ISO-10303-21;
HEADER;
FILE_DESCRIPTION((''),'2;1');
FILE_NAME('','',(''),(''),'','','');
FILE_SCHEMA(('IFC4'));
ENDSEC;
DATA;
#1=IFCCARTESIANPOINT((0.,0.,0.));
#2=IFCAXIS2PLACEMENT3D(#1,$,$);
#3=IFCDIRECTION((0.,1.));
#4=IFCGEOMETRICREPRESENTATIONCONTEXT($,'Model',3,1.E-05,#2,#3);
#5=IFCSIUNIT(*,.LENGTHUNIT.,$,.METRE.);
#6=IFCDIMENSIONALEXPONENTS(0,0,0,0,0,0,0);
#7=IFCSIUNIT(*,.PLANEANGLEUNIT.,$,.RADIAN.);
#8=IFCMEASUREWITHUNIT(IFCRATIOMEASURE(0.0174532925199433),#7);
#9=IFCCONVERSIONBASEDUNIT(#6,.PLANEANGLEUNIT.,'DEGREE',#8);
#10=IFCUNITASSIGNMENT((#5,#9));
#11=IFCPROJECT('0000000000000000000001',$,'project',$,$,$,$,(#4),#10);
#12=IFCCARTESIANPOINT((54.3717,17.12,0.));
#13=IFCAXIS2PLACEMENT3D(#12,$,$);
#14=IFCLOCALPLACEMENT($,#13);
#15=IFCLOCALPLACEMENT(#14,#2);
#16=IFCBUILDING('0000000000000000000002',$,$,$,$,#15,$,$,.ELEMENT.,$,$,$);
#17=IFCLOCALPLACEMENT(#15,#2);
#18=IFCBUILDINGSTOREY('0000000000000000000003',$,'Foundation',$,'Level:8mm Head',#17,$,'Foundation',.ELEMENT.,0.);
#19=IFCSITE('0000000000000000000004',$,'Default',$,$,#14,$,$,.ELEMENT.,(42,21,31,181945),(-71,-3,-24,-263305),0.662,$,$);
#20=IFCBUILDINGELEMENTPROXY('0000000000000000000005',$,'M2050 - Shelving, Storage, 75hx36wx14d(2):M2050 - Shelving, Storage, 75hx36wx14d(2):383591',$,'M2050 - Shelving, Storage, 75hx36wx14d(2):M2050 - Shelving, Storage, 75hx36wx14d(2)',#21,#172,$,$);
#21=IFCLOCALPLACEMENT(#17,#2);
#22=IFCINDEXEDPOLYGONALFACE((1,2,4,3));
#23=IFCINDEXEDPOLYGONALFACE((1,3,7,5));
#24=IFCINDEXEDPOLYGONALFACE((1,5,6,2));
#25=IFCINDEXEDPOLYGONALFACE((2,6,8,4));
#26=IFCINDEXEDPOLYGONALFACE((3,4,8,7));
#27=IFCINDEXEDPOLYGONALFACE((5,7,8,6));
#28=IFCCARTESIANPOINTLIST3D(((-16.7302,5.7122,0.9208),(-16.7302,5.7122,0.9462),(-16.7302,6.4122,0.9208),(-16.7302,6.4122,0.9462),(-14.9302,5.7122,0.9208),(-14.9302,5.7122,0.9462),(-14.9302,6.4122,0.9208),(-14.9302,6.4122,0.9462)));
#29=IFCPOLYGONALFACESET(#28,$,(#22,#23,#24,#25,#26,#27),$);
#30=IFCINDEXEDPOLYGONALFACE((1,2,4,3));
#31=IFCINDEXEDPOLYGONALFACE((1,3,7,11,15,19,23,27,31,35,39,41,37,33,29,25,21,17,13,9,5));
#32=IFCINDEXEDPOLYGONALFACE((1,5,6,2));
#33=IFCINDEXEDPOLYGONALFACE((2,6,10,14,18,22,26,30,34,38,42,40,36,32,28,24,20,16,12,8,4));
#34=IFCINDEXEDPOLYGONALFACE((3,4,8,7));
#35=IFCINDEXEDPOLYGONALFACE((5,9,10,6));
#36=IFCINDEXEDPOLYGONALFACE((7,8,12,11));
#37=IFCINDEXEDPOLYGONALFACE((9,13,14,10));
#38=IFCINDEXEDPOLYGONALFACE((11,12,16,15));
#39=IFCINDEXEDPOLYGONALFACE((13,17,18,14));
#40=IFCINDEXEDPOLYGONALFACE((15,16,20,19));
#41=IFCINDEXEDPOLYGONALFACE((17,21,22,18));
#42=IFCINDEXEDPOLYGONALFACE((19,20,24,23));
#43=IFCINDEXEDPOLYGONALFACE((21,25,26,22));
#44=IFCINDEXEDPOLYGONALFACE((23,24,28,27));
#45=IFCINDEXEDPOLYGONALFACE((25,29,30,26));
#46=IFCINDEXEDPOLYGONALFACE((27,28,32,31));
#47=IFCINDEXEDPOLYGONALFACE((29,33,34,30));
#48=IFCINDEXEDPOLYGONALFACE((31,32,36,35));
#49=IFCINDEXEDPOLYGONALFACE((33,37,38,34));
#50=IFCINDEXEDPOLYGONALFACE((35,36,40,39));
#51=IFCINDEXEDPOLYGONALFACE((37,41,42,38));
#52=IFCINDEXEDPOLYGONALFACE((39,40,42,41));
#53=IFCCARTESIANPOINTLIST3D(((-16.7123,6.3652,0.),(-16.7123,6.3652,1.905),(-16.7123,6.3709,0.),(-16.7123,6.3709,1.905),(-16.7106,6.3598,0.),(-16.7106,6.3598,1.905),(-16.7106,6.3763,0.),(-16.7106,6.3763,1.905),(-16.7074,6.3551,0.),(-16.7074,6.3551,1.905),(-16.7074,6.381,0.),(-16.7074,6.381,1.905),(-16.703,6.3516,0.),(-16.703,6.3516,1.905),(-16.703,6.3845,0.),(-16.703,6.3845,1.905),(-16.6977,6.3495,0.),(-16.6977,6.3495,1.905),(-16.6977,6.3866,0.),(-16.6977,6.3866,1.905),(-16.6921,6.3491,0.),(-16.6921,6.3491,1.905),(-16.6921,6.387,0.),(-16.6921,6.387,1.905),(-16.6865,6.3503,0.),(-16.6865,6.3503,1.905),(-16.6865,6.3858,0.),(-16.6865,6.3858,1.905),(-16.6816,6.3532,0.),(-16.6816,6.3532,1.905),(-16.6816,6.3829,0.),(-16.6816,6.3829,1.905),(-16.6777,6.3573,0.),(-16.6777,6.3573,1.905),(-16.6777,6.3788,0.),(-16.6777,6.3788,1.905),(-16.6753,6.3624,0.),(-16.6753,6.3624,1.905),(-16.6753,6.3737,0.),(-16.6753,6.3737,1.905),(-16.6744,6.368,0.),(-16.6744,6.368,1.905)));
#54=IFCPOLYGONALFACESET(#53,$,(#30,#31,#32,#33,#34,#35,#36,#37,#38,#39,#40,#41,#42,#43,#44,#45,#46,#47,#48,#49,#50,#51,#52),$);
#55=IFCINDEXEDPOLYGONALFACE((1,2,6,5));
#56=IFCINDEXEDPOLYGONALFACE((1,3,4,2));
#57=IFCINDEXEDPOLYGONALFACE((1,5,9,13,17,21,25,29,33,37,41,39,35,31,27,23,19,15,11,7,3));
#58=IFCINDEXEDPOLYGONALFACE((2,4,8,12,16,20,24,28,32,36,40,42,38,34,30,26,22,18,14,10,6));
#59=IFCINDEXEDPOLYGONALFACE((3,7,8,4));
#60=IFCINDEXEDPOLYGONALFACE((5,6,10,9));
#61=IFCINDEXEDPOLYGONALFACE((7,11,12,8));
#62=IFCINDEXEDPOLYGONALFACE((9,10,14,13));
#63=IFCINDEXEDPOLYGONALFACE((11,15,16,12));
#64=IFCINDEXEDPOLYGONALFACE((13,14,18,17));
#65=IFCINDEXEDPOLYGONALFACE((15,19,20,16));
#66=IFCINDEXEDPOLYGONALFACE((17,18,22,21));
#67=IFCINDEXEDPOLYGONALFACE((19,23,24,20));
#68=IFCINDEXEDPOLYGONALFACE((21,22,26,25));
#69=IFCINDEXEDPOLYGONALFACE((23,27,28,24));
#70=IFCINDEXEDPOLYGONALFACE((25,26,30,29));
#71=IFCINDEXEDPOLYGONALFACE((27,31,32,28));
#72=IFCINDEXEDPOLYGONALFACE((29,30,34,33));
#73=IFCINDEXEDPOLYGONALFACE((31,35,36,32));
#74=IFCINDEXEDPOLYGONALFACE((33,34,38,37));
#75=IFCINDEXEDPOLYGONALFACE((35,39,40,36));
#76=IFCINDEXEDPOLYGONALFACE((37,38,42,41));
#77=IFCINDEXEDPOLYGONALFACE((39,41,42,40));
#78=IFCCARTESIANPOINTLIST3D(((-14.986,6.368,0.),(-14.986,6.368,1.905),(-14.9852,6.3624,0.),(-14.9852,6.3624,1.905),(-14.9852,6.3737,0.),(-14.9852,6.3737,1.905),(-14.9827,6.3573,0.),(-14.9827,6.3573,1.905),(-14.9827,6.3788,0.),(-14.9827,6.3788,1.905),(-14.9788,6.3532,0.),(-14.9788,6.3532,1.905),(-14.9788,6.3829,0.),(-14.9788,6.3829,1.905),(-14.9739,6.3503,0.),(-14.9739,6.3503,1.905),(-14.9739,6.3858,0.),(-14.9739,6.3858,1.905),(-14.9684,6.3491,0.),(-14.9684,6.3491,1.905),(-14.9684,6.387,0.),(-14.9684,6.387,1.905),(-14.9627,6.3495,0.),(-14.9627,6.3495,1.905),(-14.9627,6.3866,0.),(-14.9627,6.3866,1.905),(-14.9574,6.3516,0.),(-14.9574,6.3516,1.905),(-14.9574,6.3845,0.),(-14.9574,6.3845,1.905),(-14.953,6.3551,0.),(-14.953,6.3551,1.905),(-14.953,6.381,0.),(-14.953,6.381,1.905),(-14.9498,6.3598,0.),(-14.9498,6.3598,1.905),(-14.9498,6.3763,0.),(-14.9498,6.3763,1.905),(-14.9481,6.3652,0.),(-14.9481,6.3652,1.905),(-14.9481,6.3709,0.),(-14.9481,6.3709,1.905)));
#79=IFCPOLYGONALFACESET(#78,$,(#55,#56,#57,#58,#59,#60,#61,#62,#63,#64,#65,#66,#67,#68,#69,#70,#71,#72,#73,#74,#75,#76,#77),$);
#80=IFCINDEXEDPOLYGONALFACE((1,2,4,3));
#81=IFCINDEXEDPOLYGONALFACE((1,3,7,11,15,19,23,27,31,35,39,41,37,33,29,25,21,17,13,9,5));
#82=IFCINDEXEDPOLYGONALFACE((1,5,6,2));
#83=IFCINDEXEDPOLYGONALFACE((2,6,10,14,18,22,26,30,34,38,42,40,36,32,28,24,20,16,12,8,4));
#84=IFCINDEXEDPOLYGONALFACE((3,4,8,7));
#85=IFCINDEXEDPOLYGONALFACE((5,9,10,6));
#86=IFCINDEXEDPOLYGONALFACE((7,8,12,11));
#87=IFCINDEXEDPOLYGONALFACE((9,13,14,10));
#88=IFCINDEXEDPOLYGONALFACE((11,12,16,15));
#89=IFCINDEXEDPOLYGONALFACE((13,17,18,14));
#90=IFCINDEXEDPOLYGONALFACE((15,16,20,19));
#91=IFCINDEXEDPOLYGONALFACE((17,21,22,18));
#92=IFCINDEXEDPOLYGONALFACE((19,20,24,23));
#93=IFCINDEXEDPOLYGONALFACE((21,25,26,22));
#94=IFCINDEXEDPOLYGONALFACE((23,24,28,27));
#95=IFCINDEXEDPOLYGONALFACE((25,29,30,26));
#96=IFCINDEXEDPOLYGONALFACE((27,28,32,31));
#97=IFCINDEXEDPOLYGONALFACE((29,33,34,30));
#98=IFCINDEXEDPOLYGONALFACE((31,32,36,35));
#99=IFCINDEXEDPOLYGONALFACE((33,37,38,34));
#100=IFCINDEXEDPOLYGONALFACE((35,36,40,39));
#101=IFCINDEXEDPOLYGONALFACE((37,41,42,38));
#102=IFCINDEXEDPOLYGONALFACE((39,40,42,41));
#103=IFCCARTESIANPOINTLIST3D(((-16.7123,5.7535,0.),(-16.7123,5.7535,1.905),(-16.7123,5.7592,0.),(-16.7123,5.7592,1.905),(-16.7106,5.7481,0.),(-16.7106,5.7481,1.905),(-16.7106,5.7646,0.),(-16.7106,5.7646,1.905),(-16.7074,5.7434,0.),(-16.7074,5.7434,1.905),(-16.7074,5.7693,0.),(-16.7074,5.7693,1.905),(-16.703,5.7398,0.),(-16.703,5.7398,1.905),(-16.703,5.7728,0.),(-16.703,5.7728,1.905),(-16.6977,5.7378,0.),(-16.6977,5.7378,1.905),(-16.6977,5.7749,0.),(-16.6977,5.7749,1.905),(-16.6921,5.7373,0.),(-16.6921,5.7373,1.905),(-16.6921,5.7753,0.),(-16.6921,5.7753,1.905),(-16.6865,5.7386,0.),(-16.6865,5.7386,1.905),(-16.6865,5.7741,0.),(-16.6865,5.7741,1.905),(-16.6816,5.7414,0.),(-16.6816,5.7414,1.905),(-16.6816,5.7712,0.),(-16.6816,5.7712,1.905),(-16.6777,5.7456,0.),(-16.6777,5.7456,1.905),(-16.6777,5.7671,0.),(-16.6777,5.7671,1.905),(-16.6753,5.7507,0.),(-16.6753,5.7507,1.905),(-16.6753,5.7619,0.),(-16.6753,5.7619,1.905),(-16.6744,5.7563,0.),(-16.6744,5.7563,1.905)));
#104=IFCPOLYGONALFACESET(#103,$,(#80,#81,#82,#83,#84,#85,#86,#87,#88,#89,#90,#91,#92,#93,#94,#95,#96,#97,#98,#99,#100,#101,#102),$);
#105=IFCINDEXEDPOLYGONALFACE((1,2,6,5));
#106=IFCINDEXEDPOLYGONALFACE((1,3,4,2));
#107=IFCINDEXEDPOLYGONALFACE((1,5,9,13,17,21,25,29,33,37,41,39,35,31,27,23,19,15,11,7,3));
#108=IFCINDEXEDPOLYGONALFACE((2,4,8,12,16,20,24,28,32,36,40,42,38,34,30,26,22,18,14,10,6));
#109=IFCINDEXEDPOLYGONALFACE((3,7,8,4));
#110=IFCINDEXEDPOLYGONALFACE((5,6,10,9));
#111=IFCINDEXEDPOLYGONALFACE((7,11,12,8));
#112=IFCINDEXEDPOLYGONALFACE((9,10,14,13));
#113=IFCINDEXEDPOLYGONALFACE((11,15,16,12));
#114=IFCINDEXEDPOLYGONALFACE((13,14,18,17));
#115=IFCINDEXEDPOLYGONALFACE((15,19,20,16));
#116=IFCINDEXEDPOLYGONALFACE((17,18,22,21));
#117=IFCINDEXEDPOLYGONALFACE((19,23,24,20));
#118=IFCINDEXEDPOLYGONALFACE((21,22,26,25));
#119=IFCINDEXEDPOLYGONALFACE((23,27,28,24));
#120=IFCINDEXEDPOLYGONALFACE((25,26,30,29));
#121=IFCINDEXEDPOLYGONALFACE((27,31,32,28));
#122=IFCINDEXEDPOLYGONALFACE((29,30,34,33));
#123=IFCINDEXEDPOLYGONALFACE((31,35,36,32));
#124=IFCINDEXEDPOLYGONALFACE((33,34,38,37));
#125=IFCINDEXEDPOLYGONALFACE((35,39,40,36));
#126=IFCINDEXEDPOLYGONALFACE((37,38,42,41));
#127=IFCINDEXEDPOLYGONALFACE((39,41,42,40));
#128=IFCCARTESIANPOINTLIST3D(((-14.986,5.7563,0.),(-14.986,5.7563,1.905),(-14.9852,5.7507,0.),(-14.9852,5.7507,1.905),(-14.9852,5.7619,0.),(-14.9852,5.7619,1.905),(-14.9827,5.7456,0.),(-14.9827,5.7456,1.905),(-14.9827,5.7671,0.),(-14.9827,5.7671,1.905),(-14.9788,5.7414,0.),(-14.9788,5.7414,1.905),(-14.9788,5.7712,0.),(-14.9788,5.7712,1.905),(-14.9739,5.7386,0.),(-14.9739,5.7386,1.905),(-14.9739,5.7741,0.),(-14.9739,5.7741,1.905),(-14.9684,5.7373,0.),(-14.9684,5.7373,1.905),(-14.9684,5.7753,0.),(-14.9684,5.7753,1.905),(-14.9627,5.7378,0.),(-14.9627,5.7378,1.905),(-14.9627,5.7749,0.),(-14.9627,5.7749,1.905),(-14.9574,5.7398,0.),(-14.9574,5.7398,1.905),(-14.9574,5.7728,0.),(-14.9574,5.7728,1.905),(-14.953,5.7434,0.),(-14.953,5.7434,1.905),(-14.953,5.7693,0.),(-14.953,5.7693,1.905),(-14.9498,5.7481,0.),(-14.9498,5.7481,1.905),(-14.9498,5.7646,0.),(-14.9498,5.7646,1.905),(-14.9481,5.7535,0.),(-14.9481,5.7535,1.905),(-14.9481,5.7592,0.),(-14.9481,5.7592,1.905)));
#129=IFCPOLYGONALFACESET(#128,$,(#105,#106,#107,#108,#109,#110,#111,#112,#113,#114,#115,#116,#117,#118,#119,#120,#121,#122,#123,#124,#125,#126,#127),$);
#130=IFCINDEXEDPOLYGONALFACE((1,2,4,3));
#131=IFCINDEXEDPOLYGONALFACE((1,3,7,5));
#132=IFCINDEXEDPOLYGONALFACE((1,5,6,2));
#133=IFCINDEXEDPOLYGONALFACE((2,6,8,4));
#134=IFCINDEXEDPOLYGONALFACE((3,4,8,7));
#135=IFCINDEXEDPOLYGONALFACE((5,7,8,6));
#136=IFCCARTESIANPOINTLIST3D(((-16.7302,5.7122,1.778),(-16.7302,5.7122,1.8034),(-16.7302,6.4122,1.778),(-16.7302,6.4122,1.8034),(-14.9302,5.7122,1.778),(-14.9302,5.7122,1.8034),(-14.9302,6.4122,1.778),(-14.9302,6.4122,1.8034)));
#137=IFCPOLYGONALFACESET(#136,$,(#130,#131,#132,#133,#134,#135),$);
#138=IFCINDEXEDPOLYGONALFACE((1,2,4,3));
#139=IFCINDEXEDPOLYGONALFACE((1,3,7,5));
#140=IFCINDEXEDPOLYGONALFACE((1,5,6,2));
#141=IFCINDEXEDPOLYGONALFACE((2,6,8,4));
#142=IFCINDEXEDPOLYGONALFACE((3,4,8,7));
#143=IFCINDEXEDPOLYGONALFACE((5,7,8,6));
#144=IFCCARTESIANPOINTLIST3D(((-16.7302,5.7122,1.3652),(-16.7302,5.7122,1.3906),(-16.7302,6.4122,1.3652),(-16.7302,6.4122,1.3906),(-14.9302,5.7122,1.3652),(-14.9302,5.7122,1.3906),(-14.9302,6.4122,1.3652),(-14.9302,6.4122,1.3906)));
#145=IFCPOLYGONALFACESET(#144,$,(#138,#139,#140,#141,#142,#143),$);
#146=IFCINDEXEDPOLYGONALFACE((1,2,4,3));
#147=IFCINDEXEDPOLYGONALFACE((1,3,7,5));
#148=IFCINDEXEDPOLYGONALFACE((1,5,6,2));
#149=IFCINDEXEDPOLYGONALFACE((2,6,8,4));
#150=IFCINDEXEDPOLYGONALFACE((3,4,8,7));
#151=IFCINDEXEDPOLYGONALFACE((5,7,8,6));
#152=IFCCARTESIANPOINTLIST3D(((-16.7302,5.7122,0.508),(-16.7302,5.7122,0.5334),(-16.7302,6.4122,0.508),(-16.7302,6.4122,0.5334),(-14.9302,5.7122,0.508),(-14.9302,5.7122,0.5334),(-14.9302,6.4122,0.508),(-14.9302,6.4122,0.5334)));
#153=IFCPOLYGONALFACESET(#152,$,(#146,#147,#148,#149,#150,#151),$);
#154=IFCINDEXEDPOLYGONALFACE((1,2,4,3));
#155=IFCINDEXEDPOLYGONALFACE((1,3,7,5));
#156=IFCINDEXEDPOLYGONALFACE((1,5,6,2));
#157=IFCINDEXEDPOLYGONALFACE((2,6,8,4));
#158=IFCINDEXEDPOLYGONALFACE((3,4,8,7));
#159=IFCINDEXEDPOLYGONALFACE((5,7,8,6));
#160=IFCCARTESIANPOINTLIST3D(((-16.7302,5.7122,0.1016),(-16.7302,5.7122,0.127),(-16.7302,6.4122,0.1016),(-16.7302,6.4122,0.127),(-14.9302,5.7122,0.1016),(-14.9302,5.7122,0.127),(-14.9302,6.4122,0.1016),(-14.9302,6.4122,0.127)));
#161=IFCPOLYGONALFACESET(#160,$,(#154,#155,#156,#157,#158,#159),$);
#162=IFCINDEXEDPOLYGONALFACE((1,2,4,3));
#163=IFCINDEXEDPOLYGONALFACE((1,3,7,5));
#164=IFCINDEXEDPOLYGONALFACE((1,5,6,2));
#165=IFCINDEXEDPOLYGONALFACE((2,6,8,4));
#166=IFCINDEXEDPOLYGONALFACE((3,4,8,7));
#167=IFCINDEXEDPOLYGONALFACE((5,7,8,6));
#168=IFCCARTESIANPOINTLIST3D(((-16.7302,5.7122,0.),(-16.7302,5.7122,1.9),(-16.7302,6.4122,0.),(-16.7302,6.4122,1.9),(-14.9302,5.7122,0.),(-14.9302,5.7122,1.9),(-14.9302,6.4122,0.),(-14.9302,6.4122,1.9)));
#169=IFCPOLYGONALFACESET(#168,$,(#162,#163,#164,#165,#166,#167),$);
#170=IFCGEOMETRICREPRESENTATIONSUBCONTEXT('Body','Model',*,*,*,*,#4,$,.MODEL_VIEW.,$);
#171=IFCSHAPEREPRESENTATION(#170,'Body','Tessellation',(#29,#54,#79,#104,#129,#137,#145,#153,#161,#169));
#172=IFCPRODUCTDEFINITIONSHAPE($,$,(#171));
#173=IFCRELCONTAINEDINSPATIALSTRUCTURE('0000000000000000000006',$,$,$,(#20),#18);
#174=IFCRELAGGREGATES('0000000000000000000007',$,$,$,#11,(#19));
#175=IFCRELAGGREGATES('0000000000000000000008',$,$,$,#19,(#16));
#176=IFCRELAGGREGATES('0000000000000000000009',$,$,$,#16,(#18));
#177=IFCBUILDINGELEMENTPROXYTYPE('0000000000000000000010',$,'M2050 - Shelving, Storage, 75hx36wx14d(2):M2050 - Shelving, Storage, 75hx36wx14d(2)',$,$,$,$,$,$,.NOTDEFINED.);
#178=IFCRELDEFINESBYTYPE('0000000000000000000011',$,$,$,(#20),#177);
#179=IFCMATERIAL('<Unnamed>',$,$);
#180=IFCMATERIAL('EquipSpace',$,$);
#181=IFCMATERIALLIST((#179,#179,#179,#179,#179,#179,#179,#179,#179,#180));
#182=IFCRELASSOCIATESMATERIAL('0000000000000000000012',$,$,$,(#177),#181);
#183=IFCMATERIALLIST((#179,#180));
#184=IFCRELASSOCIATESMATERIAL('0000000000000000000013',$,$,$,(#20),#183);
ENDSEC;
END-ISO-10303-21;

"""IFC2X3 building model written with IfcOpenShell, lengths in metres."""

from ifc_helpers import new_model, entity, si_unit, converted_unit, direction, frame, frame_2d, origin, origin_2d_with_axis, place, context, subcontext, project, spatial, rectangle, circle, extrude, source, transform, mapped, material, material_list, type_object, type_shapes, element, save


model = new_model("IFC2X3")

# Units and contexts
model_context = context("Model", 3, precision=1e-05, world=origin(), true_north=direction((0.0, 1.0)))
body_context = subcontext(model_context, "Body", "Model", "MODEL_VIEW")
ifc_project = project(units=[si_unit("LENGTHUNIT", "METRE"), converted_unit("PLANEANGLEUNIT", "DEGREE", entity("IfcRatioMeasure", 0.0174532925199433), si_unit("PLANEANGLEUNIT", "RADIAN"), dimensions=[0, 0, 0, 0, 0, 0, 0])], contexts=[model_context])

# Site, building, storey
site_placement = place(None, frame((54.3717, 17.12, 0.0)))
site = spatial("IfcSite", under=ifc_project, at=site_placement, Name="Default", CompositionType="ELEMENT", RefLatitude=(42, 21, 31, 181945), RefLongitude=(-71, -3, -24, -263305), RefElevation=0.662)
building_placement = place(site_placement, origin())
building = spatial("IfcBuilding", under=site, at=building_placement, CompositionType="ELEMENT")
storey_placement = place(building_placement, origin())
storey = spatial("IfcBuildingStorey", under=building, at=storey_placement, Name="Foundation", ObjectType="Level:8mm Head", LongName="Foundation", CompositionType="ELEMENT", Elevation=0.0)

# Building element proxy
ifc_material_1 = material(Name="<Unnamed>")
ifc_material_2 = material(Name="EquipSpace")
ifc_material_list_1 = material_list([ifc_material_1, ifc_material_1, ifc_material_1, ifc_material_1, ifc_material_1, ifc_material_1, ifc_material_1, ifc_material_1, ifc_material_1, ifc_material_2])
building_element_proxy_type = type_object("IfcBuildingElementProxyType", Name="M2050 - Shelving, Storage, 75hx36wx14d(2):M2050 - Shelving, Storage, 75hx36wx14d(2)", PredefinedType="NOTDEFINED", material=ifc_material_list_1)
shared_shape = source(origin(), body_context, "Body", "SweptSolid", [
    extrude(rectangle(XDim=1.8, YDim=0.7, at=origin_2d_with_axis()), frame((0.0, 0.0, 0.9207), z_axis=(0.0, 0.0, 1.0), x_axis=(-1.0, 0.0, 0.0)), (0.0, 0.0, 1.0), 0.0254),
    extrude(circle(Radius=0.0191, at=origin_2d_with_axis()), frame((0.8633, -0.3059, 0.0), z_axis=(0.0, 0.0, 1.0), x_axis=(-1.0, 0.0, 0.0)), (0.0, 0.0, 1.0), 1.905),
    extrude(circle(Radius=0.0191, at=origin_2d_with_axis()), frame((-0.8633, -0.3059, 0.0)), (0.0, 0.0, 1.0), 1.905),
    extrude(circle(Radius=0.0191, at=origin_2d_with_axis()), frame((0.8633, 0.3059, 0.0), z_axis=(0.0, 0.0, 1.0), x_axis=(-1.0, 0.0, 0.0)), (0.0, 0.0, 1.0), 1.905),
    extrude(circle(Radius=0.0191, at=origin_2d_with_axis()), frame((-0.8633, 0.3059, 0.0)), (0.0, 0.0, 1.0), 1.905),
    extrude(rectangle(XDim=1.8, YDim=0.7, at=origin_2d_with_axis()), frame((0.0, 0.0, 1.778), z_axis=(0.0, 0.0, 1.0), x_axis=(-1.0, 0.0, 0.0)), (0.0, 0.0, 1.0), 0.0254),
    extrude(rectangle(XDim=1.8, YDim=0.7, at=origin_2d_with_axis()), frame((0.0, 0.0, 1.3653), z_axis=(0.0, 0.0, 1.0), x_axis=(-1.0, 0.0, 0.0)), (0.0, 0.0, 1.0), 0.0254),
    extrude(rectangle(XDim=1.8, YDim=0.7, at=origin_2d_with_axis()), frame((0.0, 0.0, 0.508), z_axis=(0.0, 0.0, 1.0), x_axis=(-1.0, 0.0, 0.0)), (0.0, 0.0, 1.0), 0.0254),
    extrude(rectangle(XDim=1.8, YDim=0.7, at=origin_2d_with_axis()), frame((0.0, 0.0, 0.1016), z_axis=(0.0, 0.0, 1.0), x_axis=(-1.0, 0.0, 0.0)), (0.0, 0.0, 1.0), 0.0254),
    extrude(rectangle(XDim=0.7, YDim=1.8, at=frame_2d((0.0, 0.18), x_axis=(1.0, 0.0))), frame((-0.18, 0.0, 0.0), z_axis=(0.0, 0.0, 1.0), x_axis=(0.0, -1.0, 0.0)), (0.0, 0.0, 1.0), 1.9),
])
type_shapes(building_element_proxy_type, [shared_shape])
ifc_material_list_2 = material_list([ifc_material_1, ifc_material_2])
proxy_1_placement = place(storey_placement, frame((-15.8302, 6.0622, 0.0), z_axis=(0.0, 0.0, 1.0), x_axis=(-1.0, 0.0, 0.0)))
element("IfcBuildingElementProxy", 1, at=proxy_1_placement, inside=storey, type_object=building_element_proxy_type, material=ifc_material_list_2, Name="M2050 - Shelving, Storage, 75hx36wx14d(2):M2050 - Shelving, Storage, 75hx36wx14d(2):383591", ObjectType="M2050 - Shelving, Storage, 75hx36wx14d(2):M2050 - Shelving, Storage, 75hx36wx14d(2)", context=body_context, shape_type="MappedRepresentation", body=[
    mapped(shared_shape, transform((0.0, 0.0, 0.0), scale=1.0)),
])

save(model, "model.ifc")
